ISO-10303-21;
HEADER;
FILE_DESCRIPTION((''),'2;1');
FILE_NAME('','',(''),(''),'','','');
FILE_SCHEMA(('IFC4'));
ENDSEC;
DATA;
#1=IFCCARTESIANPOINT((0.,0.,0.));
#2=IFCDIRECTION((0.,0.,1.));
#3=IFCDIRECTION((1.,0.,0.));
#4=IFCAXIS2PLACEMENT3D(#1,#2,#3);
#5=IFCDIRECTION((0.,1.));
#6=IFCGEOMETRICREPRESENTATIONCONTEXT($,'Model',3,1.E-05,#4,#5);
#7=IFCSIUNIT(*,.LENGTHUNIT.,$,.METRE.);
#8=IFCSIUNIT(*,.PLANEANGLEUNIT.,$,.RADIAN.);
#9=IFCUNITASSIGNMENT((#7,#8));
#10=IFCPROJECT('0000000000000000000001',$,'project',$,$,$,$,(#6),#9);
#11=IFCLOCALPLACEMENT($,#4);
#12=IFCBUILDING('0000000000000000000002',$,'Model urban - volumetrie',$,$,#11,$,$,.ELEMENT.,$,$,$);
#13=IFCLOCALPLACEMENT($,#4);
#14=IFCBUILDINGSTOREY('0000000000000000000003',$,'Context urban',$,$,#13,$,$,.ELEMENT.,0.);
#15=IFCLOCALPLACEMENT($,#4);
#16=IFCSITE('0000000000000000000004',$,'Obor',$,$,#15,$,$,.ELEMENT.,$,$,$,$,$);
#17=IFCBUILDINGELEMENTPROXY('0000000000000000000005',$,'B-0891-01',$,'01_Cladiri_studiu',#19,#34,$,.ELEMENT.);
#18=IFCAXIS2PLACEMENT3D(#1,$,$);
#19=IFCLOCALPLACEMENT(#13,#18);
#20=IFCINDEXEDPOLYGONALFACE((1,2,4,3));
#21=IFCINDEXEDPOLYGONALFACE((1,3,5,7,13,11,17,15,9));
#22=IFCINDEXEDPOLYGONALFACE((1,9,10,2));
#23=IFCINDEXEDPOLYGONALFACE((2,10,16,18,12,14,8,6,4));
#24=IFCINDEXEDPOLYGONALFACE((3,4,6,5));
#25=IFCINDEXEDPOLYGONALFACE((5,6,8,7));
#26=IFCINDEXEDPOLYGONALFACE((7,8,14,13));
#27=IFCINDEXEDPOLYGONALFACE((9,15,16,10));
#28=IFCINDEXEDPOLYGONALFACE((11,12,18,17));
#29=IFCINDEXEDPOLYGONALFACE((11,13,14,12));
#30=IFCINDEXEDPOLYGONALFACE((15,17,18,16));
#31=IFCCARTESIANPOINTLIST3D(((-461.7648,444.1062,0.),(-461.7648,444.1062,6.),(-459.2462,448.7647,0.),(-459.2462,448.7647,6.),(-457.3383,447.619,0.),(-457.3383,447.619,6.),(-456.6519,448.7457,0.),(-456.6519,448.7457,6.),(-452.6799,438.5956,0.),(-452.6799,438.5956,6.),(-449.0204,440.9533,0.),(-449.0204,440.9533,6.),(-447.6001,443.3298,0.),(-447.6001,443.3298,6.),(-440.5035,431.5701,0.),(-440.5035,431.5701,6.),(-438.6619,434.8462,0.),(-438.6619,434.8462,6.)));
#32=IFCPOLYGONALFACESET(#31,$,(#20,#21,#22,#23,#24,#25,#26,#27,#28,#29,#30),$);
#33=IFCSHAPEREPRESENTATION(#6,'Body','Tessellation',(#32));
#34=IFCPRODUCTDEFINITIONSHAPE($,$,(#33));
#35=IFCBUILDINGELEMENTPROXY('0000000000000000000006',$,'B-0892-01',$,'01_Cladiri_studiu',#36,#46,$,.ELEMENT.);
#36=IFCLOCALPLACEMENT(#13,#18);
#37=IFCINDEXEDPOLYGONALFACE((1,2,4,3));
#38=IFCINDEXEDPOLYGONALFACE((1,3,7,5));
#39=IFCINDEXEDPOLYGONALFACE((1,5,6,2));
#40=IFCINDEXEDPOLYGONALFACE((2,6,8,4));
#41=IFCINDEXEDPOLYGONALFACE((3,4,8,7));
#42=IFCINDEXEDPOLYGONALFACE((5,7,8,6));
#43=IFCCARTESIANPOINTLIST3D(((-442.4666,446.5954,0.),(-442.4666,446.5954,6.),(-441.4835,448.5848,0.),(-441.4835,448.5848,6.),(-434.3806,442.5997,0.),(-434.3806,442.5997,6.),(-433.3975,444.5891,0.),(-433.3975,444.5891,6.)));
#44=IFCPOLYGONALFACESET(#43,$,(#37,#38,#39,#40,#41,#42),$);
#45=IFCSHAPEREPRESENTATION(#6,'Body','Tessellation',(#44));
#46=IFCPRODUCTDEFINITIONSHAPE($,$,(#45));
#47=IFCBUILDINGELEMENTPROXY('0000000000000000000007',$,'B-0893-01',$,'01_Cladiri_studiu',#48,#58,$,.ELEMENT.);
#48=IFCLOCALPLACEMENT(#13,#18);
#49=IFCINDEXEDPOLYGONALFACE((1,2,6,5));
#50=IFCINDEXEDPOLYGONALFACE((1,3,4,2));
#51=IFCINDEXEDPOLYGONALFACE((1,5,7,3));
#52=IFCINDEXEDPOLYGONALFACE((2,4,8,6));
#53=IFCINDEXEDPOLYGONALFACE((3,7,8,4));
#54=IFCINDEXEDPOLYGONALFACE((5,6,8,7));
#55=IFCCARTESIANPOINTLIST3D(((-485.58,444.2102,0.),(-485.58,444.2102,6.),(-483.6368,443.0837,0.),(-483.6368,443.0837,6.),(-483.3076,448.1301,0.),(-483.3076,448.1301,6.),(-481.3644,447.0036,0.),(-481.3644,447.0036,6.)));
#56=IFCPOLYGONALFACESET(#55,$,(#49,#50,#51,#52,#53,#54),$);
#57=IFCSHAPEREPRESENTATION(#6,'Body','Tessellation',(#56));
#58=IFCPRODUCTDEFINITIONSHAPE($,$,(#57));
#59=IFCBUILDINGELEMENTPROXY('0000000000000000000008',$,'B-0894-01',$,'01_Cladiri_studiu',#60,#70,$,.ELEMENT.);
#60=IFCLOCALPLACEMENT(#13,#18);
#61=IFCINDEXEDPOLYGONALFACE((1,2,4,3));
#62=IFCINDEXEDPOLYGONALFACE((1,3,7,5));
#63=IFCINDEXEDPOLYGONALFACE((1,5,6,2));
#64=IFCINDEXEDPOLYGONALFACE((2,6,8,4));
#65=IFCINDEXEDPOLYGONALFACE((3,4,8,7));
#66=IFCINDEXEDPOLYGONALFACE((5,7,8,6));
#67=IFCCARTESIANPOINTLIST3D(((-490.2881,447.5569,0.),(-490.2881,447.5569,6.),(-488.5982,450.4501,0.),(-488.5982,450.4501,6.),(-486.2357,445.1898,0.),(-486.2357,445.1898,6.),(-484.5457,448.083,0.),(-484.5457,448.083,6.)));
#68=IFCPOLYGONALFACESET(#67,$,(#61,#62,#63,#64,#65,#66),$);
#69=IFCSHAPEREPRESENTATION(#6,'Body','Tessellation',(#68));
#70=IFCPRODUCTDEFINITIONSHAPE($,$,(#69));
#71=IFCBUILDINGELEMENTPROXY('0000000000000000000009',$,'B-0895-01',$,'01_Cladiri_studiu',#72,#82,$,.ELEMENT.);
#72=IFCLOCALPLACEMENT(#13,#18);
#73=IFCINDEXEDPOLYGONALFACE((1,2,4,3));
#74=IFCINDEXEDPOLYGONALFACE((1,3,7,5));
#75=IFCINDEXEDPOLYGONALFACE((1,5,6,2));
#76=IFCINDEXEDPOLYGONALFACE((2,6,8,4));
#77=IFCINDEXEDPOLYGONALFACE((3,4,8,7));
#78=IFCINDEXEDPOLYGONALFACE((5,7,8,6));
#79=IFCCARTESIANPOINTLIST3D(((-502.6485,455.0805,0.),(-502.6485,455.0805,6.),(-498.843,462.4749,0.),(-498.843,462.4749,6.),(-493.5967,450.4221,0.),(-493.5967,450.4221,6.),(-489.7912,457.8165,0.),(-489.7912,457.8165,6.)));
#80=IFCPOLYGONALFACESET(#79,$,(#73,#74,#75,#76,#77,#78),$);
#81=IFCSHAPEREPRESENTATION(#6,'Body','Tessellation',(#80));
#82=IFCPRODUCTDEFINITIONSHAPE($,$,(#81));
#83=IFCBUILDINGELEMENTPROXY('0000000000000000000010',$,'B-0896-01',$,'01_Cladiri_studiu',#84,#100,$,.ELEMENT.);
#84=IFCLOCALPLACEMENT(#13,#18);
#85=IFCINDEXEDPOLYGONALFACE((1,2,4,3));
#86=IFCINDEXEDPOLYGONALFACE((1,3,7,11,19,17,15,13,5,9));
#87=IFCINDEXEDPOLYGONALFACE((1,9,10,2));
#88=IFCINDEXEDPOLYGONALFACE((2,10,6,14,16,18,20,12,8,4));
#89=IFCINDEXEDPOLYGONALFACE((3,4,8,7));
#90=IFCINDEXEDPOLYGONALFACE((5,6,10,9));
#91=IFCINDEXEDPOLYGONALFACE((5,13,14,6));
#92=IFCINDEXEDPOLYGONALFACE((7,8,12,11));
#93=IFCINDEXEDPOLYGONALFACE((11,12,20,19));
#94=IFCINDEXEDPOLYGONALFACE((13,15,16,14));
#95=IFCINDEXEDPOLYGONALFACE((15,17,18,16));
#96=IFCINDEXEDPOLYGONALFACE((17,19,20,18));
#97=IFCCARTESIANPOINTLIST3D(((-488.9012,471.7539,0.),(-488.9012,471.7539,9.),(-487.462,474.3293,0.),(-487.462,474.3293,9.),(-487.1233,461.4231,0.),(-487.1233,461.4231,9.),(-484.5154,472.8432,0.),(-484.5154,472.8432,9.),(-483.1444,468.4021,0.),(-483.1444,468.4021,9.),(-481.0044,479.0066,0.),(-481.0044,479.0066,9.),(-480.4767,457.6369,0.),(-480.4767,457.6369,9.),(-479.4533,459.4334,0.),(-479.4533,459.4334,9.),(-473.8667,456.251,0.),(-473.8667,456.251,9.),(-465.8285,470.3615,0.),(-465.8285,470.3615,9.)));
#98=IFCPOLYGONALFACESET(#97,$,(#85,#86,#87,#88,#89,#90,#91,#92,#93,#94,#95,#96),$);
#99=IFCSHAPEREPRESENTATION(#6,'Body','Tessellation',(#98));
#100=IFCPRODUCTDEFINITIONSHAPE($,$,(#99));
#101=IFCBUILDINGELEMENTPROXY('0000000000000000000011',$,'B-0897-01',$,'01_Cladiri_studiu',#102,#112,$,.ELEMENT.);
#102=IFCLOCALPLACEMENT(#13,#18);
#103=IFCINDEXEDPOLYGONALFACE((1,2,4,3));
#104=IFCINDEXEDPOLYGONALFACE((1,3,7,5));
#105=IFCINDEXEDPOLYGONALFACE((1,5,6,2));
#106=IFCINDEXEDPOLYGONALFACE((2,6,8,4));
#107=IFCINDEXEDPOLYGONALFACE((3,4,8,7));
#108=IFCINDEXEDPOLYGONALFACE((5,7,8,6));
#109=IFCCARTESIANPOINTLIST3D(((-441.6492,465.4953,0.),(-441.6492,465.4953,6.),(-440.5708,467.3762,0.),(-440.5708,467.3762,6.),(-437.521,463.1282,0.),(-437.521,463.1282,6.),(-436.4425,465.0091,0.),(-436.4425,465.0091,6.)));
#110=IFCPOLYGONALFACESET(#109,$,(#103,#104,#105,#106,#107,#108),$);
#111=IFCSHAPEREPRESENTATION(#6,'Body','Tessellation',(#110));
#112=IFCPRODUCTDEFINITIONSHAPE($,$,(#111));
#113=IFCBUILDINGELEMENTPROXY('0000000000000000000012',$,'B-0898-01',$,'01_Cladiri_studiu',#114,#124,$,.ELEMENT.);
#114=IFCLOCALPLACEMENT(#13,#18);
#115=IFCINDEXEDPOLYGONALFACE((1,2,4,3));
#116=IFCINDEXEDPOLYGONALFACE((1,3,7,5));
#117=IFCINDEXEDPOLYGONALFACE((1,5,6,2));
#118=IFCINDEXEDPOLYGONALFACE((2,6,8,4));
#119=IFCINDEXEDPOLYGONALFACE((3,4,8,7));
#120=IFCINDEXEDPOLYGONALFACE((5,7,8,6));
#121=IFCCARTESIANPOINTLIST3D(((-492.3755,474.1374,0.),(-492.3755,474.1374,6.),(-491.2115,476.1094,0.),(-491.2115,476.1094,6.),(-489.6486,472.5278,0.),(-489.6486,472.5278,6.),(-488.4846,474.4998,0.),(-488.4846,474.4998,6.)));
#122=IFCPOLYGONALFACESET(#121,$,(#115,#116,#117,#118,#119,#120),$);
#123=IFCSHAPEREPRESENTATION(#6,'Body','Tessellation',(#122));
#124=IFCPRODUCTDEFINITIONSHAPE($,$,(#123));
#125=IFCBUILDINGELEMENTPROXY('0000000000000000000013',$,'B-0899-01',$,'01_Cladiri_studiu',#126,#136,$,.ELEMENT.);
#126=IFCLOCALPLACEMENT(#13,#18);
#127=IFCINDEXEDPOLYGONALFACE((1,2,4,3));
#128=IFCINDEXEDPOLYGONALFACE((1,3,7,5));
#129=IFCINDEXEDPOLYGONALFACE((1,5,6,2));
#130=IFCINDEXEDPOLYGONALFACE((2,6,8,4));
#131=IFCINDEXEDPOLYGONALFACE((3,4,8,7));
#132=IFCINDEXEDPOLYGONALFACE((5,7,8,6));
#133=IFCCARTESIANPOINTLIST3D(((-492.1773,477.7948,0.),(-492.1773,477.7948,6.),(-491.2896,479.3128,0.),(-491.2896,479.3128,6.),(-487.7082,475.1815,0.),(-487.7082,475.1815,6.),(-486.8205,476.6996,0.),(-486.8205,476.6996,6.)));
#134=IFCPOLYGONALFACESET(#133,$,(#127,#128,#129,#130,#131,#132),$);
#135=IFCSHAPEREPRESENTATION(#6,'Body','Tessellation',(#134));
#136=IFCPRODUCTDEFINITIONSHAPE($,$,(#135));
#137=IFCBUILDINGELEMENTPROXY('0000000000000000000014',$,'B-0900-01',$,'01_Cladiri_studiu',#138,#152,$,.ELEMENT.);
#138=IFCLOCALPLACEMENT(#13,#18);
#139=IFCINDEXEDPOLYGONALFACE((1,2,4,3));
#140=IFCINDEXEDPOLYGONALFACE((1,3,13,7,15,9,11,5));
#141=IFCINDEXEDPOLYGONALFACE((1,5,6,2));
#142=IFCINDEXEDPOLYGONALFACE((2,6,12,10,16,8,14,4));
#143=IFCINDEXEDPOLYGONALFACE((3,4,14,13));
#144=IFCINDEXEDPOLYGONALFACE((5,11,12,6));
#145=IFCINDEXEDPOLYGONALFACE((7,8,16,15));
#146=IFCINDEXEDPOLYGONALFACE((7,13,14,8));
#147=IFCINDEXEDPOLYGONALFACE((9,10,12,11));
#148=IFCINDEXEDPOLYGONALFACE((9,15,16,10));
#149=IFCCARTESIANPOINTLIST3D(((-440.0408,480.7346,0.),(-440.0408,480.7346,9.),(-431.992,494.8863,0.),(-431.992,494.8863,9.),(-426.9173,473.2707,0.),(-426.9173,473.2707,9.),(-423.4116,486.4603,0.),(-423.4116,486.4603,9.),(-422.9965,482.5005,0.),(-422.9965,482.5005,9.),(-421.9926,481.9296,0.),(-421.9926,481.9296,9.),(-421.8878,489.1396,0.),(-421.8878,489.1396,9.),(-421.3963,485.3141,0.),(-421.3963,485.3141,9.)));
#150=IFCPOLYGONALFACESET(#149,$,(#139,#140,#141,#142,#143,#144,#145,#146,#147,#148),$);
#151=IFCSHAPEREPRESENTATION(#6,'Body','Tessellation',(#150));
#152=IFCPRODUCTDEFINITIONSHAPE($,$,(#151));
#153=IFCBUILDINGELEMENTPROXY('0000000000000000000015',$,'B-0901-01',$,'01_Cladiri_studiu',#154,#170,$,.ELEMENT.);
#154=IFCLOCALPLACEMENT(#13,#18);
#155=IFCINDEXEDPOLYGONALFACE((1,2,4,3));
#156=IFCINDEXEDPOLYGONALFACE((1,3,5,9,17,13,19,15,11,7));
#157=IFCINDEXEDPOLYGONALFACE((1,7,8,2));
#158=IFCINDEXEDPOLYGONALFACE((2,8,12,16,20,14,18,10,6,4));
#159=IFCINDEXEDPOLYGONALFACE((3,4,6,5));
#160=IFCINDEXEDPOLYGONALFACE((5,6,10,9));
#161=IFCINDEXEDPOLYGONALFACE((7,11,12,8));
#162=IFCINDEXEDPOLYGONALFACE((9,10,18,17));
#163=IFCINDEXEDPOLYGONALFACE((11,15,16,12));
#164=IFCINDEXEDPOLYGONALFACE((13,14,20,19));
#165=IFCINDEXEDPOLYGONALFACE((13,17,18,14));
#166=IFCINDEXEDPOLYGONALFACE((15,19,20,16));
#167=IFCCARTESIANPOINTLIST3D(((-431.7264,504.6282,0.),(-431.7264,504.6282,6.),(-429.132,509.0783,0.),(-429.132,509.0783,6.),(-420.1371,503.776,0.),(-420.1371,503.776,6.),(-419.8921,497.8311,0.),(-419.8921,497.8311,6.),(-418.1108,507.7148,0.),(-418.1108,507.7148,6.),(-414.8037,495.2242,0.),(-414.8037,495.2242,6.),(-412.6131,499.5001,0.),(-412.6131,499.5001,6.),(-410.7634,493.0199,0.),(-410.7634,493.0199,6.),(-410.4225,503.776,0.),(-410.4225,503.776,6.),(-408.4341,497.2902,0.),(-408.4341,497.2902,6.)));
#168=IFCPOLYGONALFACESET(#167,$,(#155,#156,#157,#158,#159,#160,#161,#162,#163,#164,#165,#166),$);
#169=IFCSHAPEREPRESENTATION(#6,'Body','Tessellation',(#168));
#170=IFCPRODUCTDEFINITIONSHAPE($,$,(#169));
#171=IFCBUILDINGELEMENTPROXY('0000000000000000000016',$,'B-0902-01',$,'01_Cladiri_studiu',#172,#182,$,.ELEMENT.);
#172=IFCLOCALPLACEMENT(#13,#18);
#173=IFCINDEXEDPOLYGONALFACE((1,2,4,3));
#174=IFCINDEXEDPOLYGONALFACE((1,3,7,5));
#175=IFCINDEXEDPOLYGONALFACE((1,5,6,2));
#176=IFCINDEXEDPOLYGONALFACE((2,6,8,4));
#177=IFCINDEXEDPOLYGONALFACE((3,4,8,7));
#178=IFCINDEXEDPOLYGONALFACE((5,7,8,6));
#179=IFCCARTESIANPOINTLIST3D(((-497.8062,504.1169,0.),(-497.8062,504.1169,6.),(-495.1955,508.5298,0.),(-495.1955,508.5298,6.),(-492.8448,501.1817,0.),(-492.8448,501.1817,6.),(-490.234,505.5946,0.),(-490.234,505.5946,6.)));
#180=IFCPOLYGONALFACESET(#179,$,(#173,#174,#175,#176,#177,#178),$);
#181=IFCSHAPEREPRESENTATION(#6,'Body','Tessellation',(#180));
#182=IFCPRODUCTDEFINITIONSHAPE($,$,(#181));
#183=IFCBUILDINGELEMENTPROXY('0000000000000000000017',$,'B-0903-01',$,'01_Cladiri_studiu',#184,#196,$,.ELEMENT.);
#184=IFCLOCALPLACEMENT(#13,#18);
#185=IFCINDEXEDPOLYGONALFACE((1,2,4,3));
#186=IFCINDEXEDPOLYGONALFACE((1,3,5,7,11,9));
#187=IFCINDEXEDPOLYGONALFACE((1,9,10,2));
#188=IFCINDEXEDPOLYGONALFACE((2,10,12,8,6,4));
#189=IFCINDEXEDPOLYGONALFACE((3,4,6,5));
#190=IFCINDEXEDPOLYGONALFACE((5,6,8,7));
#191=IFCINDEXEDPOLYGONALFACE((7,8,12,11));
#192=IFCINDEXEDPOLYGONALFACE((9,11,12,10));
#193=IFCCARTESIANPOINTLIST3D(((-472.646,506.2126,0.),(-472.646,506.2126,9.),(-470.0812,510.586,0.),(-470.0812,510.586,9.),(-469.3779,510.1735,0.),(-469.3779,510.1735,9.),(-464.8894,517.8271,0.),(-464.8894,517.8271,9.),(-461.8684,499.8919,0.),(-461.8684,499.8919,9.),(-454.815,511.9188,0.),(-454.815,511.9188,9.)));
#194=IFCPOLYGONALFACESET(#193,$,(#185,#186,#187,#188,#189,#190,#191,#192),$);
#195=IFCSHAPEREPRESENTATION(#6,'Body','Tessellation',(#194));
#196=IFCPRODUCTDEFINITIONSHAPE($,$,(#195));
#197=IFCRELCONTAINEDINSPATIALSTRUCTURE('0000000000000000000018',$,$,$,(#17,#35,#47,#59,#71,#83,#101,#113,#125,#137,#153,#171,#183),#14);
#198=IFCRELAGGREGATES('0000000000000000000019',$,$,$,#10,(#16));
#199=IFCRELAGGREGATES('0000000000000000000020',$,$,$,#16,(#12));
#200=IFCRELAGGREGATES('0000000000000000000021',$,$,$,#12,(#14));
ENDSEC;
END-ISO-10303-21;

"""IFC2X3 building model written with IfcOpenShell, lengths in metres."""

from ifc_helpers import new_model, si_unit, direction, origin_with_axes, place, context, project, spatial, polyline, outline, extrude, element, save


model = new_model("IFC2X3")

# Units and contexts
model_context = context("Model", 3, precision=1e-05, world=origin_with_axes(), true_north=direction((0.0, 1.0)))
ifc_project = project(units=[si_unit("LENGTHUNIT", "METRE"), si_unit("PLANEANGLEUNIT", "RADIAN")], contexts=[model_context])

# Site, building, storey
site_placement = place(None, origin_with_axes())
site = spatial("IfcSite", under=ifc_project, at=site_placement, Name="Obor", CompositionType="ELEMENT")
building_placement = place(None, origin_with_axes())
building = spatial("IfcBuilding", under=site, at=building_placement, Name="Model urban - volumetrie", CompositionType="ELEMENT")
storey_placement = place(None, origin_with_axes())
storey = spatial("IfcBuildingStorey", under=building, at=storey_placement, Name="Context urban", CompositionType="ELEMENT", Elevation=0.0)

# Building element proxies
proxy_1_placement = place(None, origin_with_axes())
element("IfcBuildingElementProxy", 1, at=proxy_1_placement, inside=storey, Name="B-0891-01", ObjectType="01_Cladiri_studiu", CompositionType="ELEMENT", context=model_context, shape_type="SweptSolid", body=[
    extrude(outline(polyline([(-456.6519, 448.7457), (-457.3383, 447.619), (-459.2462, 448.7647), (-461.7648, 444.1062), (-452.6799, 438.5956), (-440.5035, 431.5701), (-438.6619, 434.8462), (-449.0204, 440.9533), (-447.6001, 443.3298), (-456.6519, 448.7457)])), origin_with_axes(), (0.0, 0.0, 1.0), 6.0),
])
proxy_2_placement = place(None, origin_with_axes())
element("IfcBuildingElementProxy", 2, at=proxy_2_placement, inside=storey, Name="B-0892-01", ObjectType="01_Cladiri_studiu", CompositionType="ELEMENT", context=model_context, shape_type="SweptSolid", body=[
    extrude(outline(polyline([(-434.3806, 442.5997), (-433.3975, 444.5891), (-441.4835, 448.5848), (-442.4666, 446.5954), (-434.3806, 442.5997)])), origin_with_axes(), (0.0, 0.0, 1.0), 6.0),
])
proxy_3_placement = place(None, origin_with_axes())
element("IfcBuildingElementProxy", 3, at=proxy_3_placement, inside=storey, Name="B-0893-01", ObjectType="01_Cladiri_studiu", CompositionType="ELEMENT", context=model_context, shape_type="SweptSolid", body=[
    extrude(outline(polyline([(-481.3644, 447.0036), (-483.3076, 448.1301), (-485.58, 444.2102), (-483.6368, 443.0837), (-481.3644, 447.0036)])), origin_with_axes(), (0.0, 0.0, 1.0), 6.0),
])
proxy_4_placement = place(None, origin_with_axes())
element("IfcBuildingElementProxy", 4, at=proxy_4_placement, inside=storey, Name="B-0894-01", ObjectType="01_Cladiri_studiu", CompositionType="ELEMENT", context=model_context, shape_type="SweptSolid", body=[
    extrude(outline(polyline([(-490.2881, 447.5569), (-486.2357, 445.1898), (-484.5457, 448.083), (-488.5982, 450.4501), (-490.2881, 447.5569)])), origin_with_axes(), (0.0, 0.0, 1.0), 6.0),
])
proxy_5_placement = place(None, origin_with_axes())
element("IfcBuildingElementProxy", 5, at=proxy_5_placement, inside=storey, Name="B-0895-01", ObjectType="01_Cladiri_studiu", CompositionType="ELEMENT", context=model_context, shape_type="SweptSolid", body=[
    extrude(outline(polyline([(-493.5967, 450.4221), (-489.7912, 457.8165), (-498.843, 462.4749), (-502.6485, 455.0805), (-493.5967, 450.4221)])), origin_with_axes(), (0.0, 0.0, 1.0), 6.0),
])
proxy_6_placement = place(None, origin_with_axes())
element("IfcBuildingElementProxy", 6, at=proxy_6_placement, inside=storey, Name="B-0896-01", ObjectType="01_Cladiri_studiu", CompositionType="ELEMENT", context=model_context, shape_type="SweptSolid", body=[
    extrude(outline(polyline([(-473.8667, 456.251), (-465.8285, 470.3615), (-481.0044, 479.0066), (-484.5154, 472.8432), (-487.462, 474.3293), (-488.9012, 471.7539), (-483.1444, 468.4021), (-487.1233, 461.4231), (-480.4767, 457.6369), (-479.4533, 459.4334), (-473.8667, 456.251)])), origin_with_axes(), (0.0, 0.0, 1.0), 9.0),
])
proxy_7_placement = place(None, origin_with_axes())
element("IfcBuildingElementProxy", 7, at=proxy_7_placement, inside=storey, Name="B-0897-01", ObjectType="01_Cladiri_studiu", CompositionType="ELEMENT", context=model_context, shape_type="SweptSolid", body=[
    extrude(outline(polyline([(-436.4425, 465.0091), (-440.5708, 467.3762), (-441.6492, 465.4953), (-437.521, 463.1282), (-436.4425, 465.0091)])), origin_with_axes(), (0.0, 0.0, 1.0), 6.0),
])
proxy_8_placement = place(None, origin_with_axes())
element("IfcBuildingElementProxy", 8, at=proxy_8_placement, inside=storey, Name="B-0898-01", ObjectType="01_Cladiri_studiu", CompositionType="ELEMENT", context=model_context, shape_type="SweptSolid", body=[
    extrude(outline(polyline([(-489.6486, 472.5278), (-488.4846, 474.4998), (-491.2115, 476.1094), (-492.3755, 474.1374), (-489.6486, 472.5278)])), origin_with_axes(), (0.0, 0.0, 1.0), 6.0),
])
proxy_9_placement = place(None, origin_with_axes())
element("IfcBuildingElementProxy", 9, at=proxy_9_placement, inside=storey, Name="B-0899-01", ObjectType="01_Cladiri_studiu", CompositionType="ELEMENT", context=model_context, shape_type="SweptSolid", body=[
    extrude(outline(polyline([(-486.8205, 476.6996), (-491.2896, 479.3128), (-492.1773, 477.7948), (-487.7082, 475.1815), (-486.8205, 476.6996)])), origin_with_axes(), (0.0, 0.0, 1.0), 6.0),
])
proxy_10_placement = place(None, origin_with_axes())
element("IfcBuildingElementProxy", 10, at=proxy_10_placement, inside=storey, Name="B-0900-01", ObjectType="01_Cladiri_studiu", CompositionType="ELEMENT", context=model_context, shape_type="SweptSolid", body=[
    extrude(outline(polyline([(-431.992, 494.8863), (-440.0408, 480.7346), (-426.9173, 473.2707), (-421.9926, 481.9296), (-422.9965, 482.5005), (-421.3963, 485.3141), (-423.4116, 486.4603), (-421.8878, 489.1396), (-431.992, 494.8863)])), origin_with_axes(), (0.0, 0.0, 1.0), 9.0),
])
proxy_11_placement = place(None, origin_with_axes())
element("IfcBuildingElementProxy", 11, at=proxy_11_placement, inside=storey, Name="B-0901-01", ObjectType="01_Cladiri_studiu", CompositionType="ELEMENT", context=model_context, shape_type="SweptSolid", body=[
    extrude(outline(polyline([(-412.6131, 499.5001), (-410.4225, 503.776), (-418.1108, 507.7148), (-420.1371, 503.776), (-429.132, 509.0783), (-431.7264, 504.6282), (-419.8921, 497.8311), (-414.8037, 495.2242), (-410.7634, 493.0199), (-408.4341, 497.2902), (-412.6131, 499.5001)])), origin_with_axes(), (0.0, 0.0, 1.0), 6.0),
])
proxy_12_placement = place(None, origin_with_axes())
element("IfcBuildingElementProxy", 12, at=proxy_12_placement, inside=storey, Name="B-0902-01", ObjectType="01_Cladiri_studiu", CompositionType="ELEMENT", context=model_context, shape_type="SweptSolid", body=[
    extrude(outline(polyline([(-492.8448, 501.1817), (-490.234, 505.5946), (-495.1955, 508.5298), (-497.8062, 504.1169), (-492.8448, 501.1817)])), origin_with_axes(), (0.0, 0.0, 1.0), 6.0),
])
proxy_13_placement = place(None, origin_with_axes())
element("IfcBuildingElementProxy", 13, at=proxy_13_placement, inside=storey, Name="B-0903-01", ObjectType="01_Cladiri_studiu", CompositionType="ELEMENT", context=model_context, shape_type="SweptSolid", body=[
    extrude(outline(polyline([(-472.646, 506.2126), (-461.8684, 499.8919), (-454.815, 511.9188), (-464.8894, 517.8271), (-469.3779, 510.1735), (-470.0812, 510.586), (-472.646, 506.2126)])), origin_with_axes(), (0.0, 0.0, 1.0), 9.0),
])

save(model, "model.ifc")
